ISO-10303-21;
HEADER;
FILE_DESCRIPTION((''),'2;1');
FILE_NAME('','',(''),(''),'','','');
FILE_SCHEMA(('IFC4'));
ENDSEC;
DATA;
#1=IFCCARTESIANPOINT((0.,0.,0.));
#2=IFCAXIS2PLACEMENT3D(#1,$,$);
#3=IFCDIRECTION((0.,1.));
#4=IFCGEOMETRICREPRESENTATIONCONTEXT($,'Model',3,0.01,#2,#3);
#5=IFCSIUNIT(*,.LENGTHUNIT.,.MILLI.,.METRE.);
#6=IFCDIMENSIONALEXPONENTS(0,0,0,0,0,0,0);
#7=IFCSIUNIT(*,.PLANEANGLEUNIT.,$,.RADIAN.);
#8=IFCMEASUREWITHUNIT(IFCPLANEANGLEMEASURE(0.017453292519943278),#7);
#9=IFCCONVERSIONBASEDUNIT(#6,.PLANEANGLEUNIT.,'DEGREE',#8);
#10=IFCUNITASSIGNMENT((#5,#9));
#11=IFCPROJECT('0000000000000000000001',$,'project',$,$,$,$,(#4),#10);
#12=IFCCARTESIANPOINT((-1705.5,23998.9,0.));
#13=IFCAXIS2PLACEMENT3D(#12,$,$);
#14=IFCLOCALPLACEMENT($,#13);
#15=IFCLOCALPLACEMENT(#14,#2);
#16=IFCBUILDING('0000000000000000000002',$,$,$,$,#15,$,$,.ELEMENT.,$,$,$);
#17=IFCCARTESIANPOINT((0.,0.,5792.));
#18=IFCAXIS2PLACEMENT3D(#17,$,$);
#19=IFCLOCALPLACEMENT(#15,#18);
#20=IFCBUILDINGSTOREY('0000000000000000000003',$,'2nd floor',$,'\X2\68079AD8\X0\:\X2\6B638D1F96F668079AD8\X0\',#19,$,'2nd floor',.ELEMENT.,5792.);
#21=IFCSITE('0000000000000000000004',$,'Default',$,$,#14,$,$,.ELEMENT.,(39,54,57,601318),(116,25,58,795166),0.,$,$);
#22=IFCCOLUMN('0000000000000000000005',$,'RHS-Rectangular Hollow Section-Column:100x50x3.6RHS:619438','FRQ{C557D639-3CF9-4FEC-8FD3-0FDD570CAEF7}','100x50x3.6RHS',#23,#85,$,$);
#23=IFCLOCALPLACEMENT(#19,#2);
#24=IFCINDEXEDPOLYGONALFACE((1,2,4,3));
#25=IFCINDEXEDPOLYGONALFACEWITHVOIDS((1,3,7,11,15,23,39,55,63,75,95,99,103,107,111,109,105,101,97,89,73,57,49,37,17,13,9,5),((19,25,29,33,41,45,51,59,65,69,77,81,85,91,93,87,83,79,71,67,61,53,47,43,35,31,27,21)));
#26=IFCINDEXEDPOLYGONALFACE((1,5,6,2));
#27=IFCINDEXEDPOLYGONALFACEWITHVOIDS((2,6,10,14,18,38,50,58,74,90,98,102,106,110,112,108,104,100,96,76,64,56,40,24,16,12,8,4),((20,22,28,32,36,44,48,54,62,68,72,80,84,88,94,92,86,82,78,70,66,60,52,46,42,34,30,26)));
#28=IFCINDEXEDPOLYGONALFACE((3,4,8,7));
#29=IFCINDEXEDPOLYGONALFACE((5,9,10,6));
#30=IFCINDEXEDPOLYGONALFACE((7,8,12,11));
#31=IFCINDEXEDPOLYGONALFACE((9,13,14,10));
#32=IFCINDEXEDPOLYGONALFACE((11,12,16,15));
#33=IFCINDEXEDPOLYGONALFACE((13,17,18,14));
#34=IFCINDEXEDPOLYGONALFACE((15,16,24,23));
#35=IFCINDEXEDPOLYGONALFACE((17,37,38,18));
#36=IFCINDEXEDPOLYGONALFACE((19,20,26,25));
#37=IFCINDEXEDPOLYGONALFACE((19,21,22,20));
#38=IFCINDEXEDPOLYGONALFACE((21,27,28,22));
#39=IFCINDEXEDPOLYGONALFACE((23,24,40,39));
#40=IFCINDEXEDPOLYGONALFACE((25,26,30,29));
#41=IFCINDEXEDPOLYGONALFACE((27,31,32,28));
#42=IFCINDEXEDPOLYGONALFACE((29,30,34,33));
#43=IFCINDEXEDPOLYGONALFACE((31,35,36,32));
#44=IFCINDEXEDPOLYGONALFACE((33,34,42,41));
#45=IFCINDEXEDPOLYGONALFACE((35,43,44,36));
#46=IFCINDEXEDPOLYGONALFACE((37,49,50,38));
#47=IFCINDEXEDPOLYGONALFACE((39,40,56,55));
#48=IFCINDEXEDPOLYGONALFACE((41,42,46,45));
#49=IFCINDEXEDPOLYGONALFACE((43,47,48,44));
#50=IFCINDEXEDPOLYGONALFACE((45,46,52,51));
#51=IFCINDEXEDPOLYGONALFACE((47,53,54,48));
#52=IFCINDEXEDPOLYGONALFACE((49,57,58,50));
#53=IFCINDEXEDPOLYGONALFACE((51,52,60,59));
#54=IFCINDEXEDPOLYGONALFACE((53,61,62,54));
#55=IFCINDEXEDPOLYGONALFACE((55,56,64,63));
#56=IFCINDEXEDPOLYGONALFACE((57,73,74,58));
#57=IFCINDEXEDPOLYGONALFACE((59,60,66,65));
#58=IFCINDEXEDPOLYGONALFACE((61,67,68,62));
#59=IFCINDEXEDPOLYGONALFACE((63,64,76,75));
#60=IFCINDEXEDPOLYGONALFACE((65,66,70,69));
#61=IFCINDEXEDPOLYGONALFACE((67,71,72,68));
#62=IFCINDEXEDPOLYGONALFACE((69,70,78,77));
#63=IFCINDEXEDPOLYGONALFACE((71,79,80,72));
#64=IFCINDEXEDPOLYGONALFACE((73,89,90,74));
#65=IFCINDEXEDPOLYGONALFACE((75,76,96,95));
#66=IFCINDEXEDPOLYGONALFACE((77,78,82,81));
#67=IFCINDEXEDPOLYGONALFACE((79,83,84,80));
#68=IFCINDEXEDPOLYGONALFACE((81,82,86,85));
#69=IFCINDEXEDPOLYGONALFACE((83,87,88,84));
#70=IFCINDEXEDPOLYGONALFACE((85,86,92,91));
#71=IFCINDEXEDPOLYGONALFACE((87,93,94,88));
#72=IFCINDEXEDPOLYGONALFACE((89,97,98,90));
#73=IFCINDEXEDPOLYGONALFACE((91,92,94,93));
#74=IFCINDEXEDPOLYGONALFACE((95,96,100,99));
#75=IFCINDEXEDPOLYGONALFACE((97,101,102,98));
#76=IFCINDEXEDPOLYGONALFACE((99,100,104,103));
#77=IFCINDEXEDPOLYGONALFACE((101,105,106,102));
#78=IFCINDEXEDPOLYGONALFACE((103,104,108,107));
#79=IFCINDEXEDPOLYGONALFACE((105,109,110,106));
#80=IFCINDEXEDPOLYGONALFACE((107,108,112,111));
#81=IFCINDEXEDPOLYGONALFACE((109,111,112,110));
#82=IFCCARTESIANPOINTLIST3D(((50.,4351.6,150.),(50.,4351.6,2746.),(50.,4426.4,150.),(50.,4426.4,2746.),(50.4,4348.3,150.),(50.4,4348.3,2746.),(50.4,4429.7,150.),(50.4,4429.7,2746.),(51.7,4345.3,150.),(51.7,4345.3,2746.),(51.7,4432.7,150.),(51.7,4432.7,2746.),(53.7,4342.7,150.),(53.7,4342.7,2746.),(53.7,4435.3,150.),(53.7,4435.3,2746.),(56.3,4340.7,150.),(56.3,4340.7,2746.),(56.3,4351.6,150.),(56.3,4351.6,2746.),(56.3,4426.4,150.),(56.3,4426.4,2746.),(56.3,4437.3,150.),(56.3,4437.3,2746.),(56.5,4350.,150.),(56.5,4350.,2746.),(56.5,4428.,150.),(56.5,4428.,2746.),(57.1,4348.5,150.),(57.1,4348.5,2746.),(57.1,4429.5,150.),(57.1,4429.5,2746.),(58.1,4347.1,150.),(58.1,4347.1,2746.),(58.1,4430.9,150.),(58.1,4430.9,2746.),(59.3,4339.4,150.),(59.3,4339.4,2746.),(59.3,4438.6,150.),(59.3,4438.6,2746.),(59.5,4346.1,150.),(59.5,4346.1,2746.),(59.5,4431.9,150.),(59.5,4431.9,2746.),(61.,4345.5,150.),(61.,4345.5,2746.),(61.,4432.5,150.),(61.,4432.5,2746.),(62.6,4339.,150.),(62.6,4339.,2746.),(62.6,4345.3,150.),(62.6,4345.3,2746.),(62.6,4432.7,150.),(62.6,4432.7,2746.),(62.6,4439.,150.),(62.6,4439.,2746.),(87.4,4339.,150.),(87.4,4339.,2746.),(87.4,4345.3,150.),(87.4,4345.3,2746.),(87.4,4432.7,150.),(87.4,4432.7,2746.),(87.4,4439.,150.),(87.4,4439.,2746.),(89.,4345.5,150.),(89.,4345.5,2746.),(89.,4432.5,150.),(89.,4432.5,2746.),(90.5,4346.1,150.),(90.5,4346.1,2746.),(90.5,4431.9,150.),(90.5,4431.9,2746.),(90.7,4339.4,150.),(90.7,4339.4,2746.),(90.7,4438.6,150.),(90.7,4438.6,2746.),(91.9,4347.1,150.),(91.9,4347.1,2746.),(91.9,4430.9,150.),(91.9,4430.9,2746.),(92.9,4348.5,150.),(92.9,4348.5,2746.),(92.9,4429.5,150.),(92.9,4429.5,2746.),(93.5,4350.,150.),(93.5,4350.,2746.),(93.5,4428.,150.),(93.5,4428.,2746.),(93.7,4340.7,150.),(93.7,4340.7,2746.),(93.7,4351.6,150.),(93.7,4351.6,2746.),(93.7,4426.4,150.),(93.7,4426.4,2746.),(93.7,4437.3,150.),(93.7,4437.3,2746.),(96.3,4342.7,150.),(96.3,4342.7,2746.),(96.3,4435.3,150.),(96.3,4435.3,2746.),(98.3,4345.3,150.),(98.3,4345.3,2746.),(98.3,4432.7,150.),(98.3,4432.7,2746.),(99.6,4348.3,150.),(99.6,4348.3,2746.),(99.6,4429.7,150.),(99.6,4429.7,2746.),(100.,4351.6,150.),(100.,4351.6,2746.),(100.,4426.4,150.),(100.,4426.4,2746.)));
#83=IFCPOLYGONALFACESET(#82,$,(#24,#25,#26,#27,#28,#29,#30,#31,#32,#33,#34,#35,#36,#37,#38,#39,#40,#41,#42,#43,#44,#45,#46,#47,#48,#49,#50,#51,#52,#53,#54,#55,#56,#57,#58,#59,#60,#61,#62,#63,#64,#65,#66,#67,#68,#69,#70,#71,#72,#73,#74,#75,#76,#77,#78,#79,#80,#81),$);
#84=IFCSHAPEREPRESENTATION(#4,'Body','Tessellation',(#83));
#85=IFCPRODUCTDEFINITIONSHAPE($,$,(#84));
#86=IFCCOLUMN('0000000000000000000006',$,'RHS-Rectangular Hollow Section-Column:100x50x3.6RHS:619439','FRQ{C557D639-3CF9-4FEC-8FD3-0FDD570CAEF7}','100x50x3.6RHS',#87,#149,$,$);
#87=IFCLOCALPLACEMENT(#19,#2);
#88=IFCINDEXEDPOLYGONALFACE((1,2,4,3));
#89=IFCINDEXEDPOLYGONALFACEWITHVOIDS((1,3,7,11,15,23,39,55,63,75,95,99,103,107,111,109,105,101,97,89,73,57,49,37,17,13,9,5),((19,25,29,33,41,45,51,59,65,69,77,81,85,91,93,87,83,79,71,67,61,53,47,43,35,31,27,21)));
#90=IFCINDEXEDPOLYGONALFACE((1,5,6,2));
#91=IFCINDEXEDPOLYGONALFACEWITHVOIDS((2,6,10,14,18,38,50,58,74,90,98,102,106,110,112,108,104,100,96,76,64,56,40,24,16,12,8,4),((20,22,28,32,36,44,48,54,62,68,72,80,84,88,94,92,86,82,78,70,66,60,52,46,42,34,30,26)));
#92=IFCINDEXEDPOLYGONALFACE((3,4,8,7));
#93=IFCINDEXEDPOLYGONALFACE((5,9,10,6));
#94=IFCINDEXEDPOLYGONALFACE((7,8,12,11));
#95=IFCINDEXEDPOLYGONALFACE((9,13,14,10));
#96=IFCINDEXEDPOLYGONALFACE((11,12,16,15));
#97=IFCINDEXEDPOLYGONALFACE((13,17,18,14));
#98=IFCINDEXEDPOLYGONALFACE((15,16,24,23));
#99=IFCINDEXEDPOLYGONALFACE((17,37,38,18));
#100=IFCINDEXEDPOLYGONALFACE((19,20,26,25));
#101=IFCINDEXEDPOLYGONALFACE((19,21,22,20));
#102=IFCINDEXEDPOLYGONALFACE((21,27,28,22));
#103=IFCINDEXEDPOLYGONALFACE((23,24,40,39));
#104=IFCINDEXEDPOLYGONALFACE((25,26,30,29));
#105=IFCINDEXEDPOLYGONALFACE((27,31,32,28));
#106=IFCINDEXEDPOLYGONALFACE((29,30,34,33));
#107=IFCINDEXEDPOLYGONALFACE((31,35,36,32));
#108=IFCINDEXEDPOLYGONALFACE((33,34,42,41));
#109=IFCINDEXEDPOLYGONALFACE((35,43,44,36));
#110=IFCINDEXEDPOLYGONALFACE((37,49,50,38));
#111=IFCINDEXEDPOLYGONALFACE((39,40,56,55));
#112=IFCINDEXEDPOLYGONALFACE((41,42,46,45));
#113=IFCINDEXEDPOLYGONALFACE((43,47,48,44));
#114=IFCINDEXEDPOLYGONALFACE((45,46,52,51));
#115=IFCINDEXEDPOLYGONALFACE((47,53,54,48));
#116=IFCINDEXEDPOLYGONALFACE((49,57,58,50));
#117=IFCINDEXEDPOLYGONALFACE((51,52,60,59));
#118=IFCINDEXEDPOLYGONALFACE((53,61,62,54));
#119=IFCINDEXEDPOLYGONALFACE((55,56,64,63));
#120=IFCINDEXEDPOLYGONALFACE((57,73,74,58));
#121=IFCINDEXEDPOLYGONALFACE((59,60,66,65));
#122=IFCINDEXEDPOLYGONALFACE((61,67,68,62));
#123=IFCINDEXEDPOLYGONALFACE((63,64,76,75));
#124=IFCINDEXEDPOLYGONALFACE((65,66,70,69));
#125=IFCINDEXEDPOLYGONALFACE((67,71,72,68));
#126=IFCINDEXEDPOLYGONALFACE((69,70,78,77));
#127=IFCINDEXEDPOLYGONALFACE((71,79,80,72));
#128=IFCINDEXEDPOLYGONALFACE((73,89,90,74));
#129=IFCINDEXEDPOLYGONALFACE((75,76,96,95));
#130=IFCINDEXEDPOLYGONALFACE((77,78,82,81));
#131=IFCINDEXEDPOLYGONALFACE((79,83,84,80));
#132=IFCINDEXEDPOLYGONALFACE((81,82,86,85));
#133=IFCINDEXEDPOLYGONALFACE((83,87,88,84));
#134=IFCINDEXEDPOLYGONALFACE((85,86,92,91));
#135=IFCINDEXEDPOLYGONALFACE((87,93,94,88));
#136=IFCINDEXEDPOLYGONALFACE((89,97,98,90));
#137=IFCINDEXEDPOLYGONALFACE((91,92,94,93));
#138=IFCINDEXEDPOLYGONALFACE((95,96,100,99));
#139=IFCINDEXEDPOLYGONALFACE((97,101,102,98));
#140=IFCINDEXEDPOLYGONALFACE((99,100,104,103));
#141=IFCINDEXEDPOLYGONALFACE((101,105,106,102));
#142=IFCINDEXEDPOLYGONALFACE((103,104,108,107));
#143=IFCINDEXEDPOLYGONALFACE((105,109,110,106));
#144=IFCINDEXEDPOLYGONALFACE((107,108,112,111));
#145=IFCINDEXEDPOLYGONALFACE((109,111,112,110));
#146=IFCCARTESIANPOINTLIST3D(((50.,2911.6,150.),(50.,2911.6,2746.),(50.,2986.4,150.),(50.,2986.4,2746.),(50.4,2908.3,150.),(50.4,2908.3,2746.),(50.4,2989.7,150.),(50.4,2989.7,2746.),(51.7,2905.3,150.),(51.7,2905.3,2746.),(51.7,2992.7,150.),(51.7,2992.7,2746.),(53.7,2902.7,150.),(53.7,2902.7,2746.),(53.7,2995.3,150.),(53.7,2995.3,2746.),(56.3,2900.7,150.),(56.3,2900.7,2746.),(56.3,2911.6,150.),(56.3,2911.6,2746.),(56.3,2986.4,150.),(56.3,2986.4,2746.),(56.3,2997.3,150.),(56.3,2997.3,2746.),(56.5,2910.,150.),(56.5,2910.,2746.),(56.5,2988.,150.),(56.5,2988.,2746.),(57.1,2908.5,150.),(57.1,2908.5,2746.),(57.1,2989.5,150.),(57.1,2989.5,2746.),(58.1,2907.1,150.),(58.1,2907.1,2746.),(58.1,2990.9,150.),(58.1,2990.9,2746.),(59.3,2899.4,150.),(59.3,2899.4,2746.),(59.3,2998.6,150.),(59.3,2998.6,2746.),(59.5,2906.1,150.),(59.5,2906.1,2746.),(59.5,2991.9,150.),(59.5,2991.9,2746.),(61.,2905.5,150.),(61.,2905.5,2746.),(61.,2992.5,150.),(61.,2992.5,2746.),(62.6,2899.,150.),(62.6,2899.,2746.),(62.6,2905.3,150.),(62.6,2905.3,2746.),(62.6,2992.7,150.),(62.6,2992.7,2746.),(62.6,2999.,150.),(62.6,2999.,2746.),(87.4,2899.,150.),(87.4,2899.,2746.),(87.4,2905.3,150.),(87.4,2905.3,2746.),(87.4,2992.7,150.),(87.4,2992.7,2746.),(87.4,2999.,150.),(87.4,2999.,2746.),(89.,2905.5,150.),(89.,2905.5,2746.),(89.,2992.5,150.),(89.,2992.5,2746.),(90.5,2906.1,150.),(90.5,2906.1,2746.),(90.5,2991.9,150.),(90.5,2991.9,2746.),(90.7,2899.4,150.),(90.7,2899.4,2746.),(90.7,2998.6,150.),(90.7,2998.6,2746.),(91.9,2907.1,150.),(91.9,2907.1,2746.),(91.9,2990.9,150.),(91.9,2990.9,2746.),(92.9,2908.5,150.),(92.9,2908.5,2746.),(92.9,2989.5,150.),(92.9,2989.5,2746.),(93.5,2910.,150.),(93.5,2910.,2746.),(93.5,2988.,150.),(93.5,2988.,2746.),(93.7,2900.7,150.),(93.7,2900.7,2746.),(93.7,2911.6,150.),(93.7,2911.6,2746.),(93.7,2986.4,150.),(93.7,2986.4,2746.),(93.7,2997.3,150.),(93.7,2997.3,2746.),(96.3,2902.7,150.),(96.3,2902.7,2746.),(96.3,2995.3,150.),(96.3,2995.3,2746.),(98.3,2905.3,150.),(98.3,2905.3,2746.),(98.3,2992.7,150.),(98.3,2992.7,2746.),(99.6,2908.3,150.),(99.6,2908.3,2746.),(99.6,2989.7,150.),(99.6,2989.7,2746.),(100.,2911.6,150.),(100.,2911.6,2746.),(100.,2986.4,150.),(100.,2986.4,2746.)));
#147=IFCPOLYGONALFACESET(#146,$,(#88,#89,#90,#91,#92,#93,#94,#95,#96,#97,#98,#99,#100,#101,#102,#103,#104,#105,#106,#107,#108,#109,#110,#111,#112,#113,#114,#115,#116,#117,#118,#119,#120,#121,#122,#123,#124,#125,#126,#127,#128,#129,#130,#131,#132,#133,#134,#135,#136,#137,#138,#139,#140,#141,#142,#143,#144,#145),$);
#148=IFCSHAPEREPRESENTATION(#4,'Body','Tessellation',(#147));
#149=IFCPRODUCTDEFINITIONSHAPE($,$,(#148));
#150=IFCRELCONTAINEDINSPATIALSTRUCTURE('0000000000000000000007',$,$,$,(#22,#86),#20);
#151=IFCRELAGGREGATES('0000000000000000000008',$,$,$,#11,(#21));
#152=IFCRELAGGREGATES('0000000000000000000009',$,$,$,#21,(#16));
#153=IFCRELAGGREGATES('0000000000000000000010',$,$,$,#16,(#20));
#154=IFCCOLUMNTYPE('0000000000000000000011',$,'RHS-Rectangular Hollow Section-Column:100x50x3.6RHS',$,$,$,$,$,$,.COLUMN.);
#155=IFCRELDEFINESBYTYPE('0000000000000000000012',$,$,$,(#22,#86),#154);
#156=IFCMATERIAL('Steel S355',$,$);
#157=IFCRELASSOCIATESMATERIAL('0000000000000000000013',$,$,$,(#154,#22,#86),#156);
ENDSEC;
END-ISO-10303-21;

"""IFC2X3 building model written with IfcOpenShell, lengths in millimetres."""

from ifc_helpers import new_model, entity, si_unit, converted_unit, point, direction, frame, frame_2d, origin, origin_2d, place, context, project, spatial, circle_curve, line_curve, trimmed, segment, composite_curve, hollow_rectangle, outline, extrude, clip, halfspace, material, type_object, element, save


model = new_model("IFC2X3")

# Units and contexts
model_context = context("Model", 3, precision=0.01, world=origin(), true_north=direction((0.0, 1.0)))
ifc_project = project(units=[si_unit("LENGTHUNIT", "METRE", prefix="MILLI"), converted_unit("PLANEANGLEUNIT", "DEGREE", entity("IfcPlaneAngleMeasure", 0.017453292519943278), si_unit("PLANEANGLEUNIT", "RADIAN"), dimensions=[0, 0, 0, 0, 0, 0, 0])], contexts=[model_context])

# Site, building, storey
site_placement = place(None, frame((-1705.5, 23998.9, 0.0)))
site = spatial("IfcSite", under=ifc_project, at=site_placement, Name="Default", CompositionType="ELEMENT", RefLatitude=(39, 54, 57, 601318), RefLongitude=(116, 25, 58, 795166), RefElevation=0.0)
building_placement = place(site_placement, origin())
building = spatial("IfcBuilding", under=site, at=building_placement, CompositionType="ELEMENT")
storey_placement = place(building_placement, frame((0.0, 0.0, 5792.0)))
storey = spatial("IfcBuildingStorey", under=building, at=storey_placement, Name="2nd floor", ObjectType="标高:正负零标高", LongName="2nd floor", CompositionType="ELEMENT", Elevation=5792.0)

# Shared definitions
ifc_material_1 = material(Name="Steel S355")

# Shared definitions
column_type_1 = type_object("IfcColumnType", Name="RHS-Rectangular Hollow Section-Column:100x50x3.6RHS", PredefinedType="COLUMN", material=ifc_material_1)

# Columns, openings
column_1_placement = place(storey_placement, frame((75.0, 4389.0, 2876.9)))
column_1 = element("IfcColumn", 1, at=column_1_placement, inside=storey, type_object=column_type_1, material=ifc_material_1, Name="RHS-Rectangular Hollow Section-Column:100x50x3.6RHS:619438", Description="FRQ{C557D639-3CF9-4FEC-8FD3-0FDD570CAEF7}", ObjectType="100x50x3.6RHS", context=model_context, shape_type="Clipping", body=[
    clip(clip(extrude(hollow_rectangle(XDim=50.0, YDim=100.0, WallThickness=6.3, InnerFilletRadius=6.3, OuterFilletRadius=12.6, at=origin_2d()), origin(), (0.0, 0.0, -1.0), 2782.8), halfspace(frame((-75.0, -4389.0, -2726.9), z_axis=(0.0, 0.0, 1.0), x_axis=(1.0, 0.0, 0.0)), True)), halfspace(frame((-75.0, -4389.0, -55.9), z_axis=(0.0, 0.0, -1.0), x_axis=(-1.0, 0.0, 0.0)), True)),
])
opening_1_placement = place(column_1_placement, frame((0.0, -150.1, -130.9), z_axis=(0.0, 1.0, 0.0), x_axis=(-1.0, 0.0, 0.0)))
element("IfcOpeningElement", 2, at=opening_1_placement, cuts=column_1, ObjectType="Opening", context=model_context, shape_type="SweptSolid", body=[
    extrude(outline(composite_curve([segment(trimmed(circle_curve(frame_2d((43.0, 32.0), x_axis=(1.0, 0.0)), 32.0), [point((43.0, 0.0))], [point((75.0, 32.0))], True, "CARTESIAN"), True, "CONTINUOUS"), segment(trimmed(line_curve((75.0, 32.0), (0.0, 1.0), 86.0), [point((75.0, 32.0))], [point((75.0, 118.0))], True, "CARTESIAN"), True, "CONTINUOUS"), segment(trimmed(circle_curve(frame_2d((43.0, 118.0), x_axis=(1.0, 0.0)), 32.0), [point((75.0, 118.0))], [point((43.0, 150.0))], True, "CARTESIAN"), True, "CONTINUOUS"), segment(trimmed(line_curve((43.0, 150.0), (-1.0, 0.0), 86.0), [point((43.0, 150.0))], [point((-43.0, 150.0))], True, "CARTESIAN"), True, "CONTINUOUS"), segment(trimmed(circle_curve(frame_2d((-43.0, 118.0), x_axis=(1.0, 0.0)), 32.0), [point((-43.0, 150.0))], [point((-75.0, 118.0))], True, "CARTESIAN"), True, "CONTINUOUS"), segment(trimmed(line_curve((-75.0, 118.0), (0.0, -1.0), 86.0), [point((-75.0, 118.0))], [point((-75.0, 32.0))], True, "CARTESIAN"), True, "CONTINUOUS"), segment(trimmed(circle_curve(frame_2d((-43.0, 32.0), x_axis=(1.0, 0.0)), 32.0), [point((-75.0, 32.0))], [point((-43.0, 0.0))], True, "CARTESIAN"), True, "CONTINUOUS"), segment(trimmed(line_curve((-43.0, 0.0), (1.0, 0.0), 86.0), [point((-43.0, 0.0))], [point((43.0, 0.0))], True, "CARTESIAN"), True, "CONTINUOUS")], self_intersect="UNKNOWN")), origin(), (0.0, 0.0, 1.0), 300.2),
])
column_2_placement = place(storey_placement, frame((75.0, 2949.0, 2876.9)))
column_2 = element("IfcColumn", 3, at=column_2_placement, inside=storey, type_object=column_type_1, material=ifc_material_1, Name="RHS-Rectangular Hollow Section-Column:100x50x3.6RHS:619439", Description="FRQ{C557D639-3CF9-4FEC-8FD3-0FDD570CAEF7}", ObjectType="100x50x3.6RHS", context=model_context, shape_type="Clipping", body=[
    clip(clip(extrude(hollow_rectangle(XDim=50.0, YDim=100.0, WallThickness=6.3, InnerFilletRadius=6.3, OuterFilletRadius=12.6, at=origin_2d()), origin(), (0.0, 0.0, -1.0), 2782.8), halfspace(frame((-75.0, -2949.0, -55.9), z_axis=(0.0, 0.0, -1.0), x_axis=(-1.0, 0.0, 0.0)), True)), halfspace(frame((-75.0, -2949.0, -2726.9), z_axis=(0.0, 0.0, 1.0), x_axis=(1.0, 0.0, 0.0)), True)),
])
opening_2_placement = place(column_2_placement, frame((0.0, -150.1, -130.9), z_axis=(0.0, 1.0, 0.0), x_axis=(-1.0, 0.0, 0.0)))
element("IfcOpeningElement", 4, at=opening_2_placement, cuts=column_2, ObjectType="Opening", context=model_context, shape_type="SweptSolid", body=[
    extrude(outline(composite_curve([segment(trimmed(circle_curve(frame_2d((43.0, 32.0), x_axis=(1.0, 0.0)), 32.0), [point((43.0, 0.0))], [point((75.0, 32.0))], True, "CARTESIAN"), True, "CONTINUOUS"), segment(trimmed(line_curve((75.0, 32.0), (0.0, 1.0), 86.0), [point((75.0, 32.0))], [point((75.0, 118.0))], True, "CARTESIAN"), True, "CONTINUOUS"), segment(trimmed(circle_curve(frame_2d((43.0, 118.0), x_axis=(1.0, 0.0)), 32.0), [point((75.0, 118.0))], [point((43.0, 150.0))], True, "CARTESIAN"), True, "CONTINUOUS"), segment(trimmed(line_curve((43.0, 150.0), (-1.0, 0.0), 86.0), [point((43.0, 150.0))], [point((-43.0, 150.0))], True, "CARTESIAN"), True, "CONTINUOUS"), segment(trimmed(circle_curve(frame_2d((-43.0, 118.0), x_axis=(1.0, 0.0)), 32.0), [point((-43.0, 150.0))], [point((-75.0, 118.0))], True, "CARTESIAN"), True, "CONTINUOUS"), segment(trimmed(line_curve((-75.0, 118.0), (0.0, -1.0), 86.0), [point((-75.0, 118.0))], [point((-75.0, 32.0))], True, "CARTESIAN"), True, "CONTINUOUS"), segment(trimmed(circle_curve(frame_2d((-43.0, 32.0), x_axis=(1.0, 0.0)), 32.0), [point((-75.0, 32.0))], [point((-43.0, 0.0))], True, "CARTESIAN"), True, "CONTINUOUS"), segment(trimmed(line_curve((-43.0, 0.0), (1.0, 0.0), 86.0), [point((-43.0, 0.0))], [point((43.0, 0.0))], True, "CARTESIAN"), True, "CONTINUOUS")], self_intersect="UNKNOWN")), origin(), (0.0, 0.0, 1.0), 300.2),
])

save(model, "model.ifc")
